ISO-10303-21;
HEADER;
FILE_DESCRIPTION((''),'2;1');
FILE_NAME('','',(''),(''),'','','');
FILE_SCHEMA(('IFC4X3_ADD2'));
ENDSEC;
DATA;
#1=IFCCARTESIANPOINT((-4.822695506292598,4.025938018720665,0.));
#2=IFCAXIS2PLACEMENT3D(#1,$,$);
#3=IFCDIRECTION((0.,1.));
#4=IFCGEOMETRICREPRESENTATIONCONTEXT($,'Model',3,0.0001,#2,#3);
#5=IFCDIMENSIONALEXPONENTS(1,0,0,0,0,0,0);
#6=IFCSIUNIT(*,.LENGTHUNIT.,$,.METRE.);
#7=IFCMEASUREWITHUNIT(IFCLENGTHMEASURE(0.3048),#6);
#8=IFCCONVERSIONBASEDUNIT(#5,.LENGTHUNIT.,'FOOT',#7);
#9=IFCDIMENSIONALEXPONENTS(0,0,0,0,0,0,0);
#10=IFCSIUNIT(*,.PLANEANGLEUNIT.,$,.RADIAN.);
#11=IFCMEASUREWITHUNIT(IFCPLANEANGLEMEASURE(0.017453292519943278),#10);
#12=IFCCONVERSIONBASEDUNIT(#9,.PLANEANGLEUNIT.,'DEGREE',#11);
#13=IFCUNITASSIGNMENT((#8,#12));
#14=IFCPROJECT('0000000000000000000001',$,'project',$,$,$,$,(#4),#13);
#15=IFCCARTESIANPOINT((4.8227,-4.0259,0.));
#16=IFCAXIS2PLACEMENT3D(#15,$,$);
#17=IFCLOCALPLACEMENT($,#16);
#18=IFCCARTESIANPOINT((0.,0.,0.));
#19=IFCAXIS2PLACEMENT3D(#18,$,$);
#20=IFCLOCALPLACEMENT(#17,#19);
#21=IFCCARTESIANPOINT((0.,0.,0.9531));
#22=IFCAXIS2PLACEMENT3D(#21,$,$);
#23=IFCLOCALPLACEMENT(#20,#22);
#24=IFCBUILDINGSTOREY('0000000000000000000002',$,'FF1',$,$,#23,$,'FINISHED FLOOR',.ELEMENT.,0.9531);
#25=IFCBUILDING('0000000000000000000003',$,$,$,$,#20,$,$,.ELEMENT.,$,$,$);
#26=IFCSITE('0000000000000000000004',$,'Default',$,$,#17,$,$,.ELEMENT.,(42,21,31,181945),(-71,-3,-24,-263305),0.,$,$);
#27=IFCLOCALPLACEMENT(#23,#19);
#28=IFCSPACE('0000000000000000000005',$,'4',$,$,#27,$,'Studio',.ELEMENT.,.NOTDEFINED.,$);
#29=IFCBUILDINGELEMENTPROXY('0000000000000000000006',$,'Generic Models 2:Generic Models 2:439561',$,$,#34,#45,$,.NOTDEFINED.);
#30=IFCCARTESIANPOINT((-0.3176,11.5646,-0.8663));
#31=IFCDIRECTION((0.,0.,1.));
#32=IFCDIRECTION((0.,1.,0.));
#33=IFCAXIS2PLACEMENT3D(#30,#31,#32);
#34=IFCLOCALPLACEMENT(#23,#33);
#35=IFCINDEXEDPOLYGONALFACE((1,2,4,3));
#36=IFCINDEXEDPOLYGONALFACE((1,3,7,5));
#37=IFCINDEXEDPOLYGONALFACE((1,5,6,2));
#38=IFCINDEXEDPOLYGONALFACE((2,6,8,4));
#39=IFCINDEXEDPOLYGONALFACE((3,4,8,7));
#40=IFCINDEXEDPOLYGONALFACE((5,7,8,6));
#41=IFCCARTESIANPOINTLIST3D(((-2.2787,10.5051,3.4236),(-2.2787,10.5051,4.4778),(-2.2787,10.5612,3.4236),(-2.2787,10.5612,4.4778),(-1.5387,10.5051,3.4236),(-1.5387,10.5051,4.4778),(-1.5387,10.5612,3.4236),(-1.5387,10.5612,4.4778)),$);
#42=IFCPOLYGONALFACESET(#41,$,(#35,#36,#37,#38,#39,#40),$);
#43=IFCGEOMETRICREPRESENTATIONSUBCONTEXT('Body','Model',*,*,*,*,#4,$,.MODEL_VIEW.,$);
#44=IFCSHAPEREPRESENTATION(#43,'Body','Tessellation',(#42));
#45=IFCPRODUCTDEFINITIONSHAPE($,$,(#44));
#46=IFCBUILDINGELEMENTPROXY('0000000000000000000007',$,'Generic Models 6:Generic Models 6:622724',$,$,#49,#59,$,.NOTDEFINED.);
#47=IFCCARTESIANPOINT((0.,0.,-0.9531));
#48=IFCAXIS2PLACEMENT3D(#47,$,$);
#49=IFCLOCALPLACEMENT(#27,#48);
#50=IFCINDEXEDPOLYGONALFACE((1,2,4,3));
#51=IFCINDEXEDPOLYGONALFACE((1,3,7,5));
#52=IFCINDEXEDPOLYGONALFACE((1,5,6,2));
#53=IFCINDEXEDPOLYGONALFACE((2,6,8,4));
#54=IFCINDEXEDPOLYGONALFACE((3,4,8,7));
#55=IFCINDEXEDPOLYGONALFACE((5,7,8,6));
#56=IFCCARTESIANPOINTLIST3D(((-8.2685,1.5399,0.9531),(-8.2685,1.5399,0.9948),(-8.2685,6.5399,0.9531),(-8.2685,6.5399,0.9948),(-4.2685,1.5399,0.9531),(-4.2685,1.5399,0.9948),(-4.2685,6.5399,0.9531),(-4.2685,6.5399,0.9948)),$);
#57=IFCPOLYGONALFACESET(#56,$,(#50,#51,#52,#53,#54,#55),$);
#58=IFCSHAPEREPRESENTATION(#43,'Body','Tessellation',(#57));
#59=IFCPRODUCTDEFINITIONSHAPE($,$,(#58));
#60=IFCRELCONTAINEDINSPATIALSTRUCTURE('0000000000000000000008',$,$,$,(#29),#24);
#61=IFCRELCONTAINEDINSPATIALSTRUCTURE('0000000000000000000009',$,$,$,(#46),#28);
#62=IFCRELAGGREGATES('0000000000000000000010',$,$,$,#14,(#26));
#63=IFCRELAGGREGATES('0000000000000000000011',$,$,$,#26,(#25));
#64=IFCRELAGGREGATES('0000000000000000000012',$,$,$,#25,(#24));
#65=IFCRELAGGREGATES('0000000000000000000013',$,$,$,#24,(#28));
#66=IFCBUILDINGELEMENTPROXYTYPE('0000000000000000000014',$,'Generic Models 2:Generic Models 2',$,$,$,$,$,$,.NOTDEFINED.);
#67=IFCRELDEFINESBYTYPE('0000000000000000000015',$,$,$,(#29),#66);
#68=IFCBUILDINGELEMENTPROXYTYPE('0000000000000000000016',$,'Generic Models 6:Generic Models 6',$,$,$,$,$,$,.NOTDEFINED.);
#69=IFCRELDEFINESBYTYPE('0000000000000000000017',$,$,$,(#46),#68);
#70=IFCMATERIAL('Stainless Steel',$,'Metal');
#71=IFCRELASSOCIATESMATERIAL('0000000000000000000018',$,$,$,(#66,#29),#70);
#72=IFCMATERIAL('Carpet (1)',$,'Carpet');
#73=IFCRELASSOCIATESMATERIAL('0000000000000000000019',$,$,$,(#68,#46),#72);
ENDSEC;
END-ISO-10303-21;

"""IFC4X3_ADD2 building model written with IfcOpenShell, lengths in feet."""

from ifc_helpers import new_model, entity, si_unit, converted_unit, direction, frame, frame_2d, origin, place, context, subcontext, project, spatial, rectangle, extrude, source, transform, mapped, material, type_object, type_shapes, element, save


model = new_model("IFC4X3_ADD2")

# Units and contexts
model_context = context("Model", 3, precision=0.0001, world=frame((-4.822695506292598, 4.025938018720665, 0.0)), true_north=direction((0.0, 1.0)))
body_context = subcontext(model_context, "Body", "Model", "MODEL_VIEW")
ifc_project = project(units=[converted_unit("LENGTHUNIT", "FOOT", entity("IfcLengthMeasure", 0.3048), si_unit("LENGTHUNIT", "METRE"), dimensions=[1, 0, 0, 0, 0, 0, 0]), converted_unit("PLANEANGLEUNIT", "DEGREE", entity("IfcPlaneAngleMeasure", 0.017453292519943278), si_unit("PLANEANGLEUNIT", "RADIAN"), dimensions=[0, 0, 0, 0, 0, 0, 0])], contexts=[model_context])

# Site, building, storey
site_placement = place(None, frame((4.8227, -4.0259, 0.0)))
site = spatial("IfcSite", under=ifc_project, at=site_placement, Name="Default", CompositionType="ELEMENT", RefLatitude=(42, 21, 31, 181945), RefLongitude=(-71, -3, -24, -263305), RefElevation=0.0)
building_placement = place(site_placement, origin())
building = spatial("IfcBuilding", under=site, at=building_placement, CompositionType="ELEMENT")
storey_placement = place(building_placement, frame((0.0, 0.0, 0.9531)))
storey = spatial("IfcBuildingStorey", under=building, at=storey_placement, Name="FF1", LongName="FINISHED FLOOR", CompositionType="ELEMENT", Elevation=0.9531)

# Shared definitions
space_placement = place(storey_placement, origin())
space = spatial("IfcSpace", under=storey, at=space_placement, Name="4", LongName="Studio", CompositionType="ELEMENT", PredefinedType="NOTDEFINED")

# Building element proxies
ifc_material_1 = material(Name="Stainless Steel", Category="Metal")
building_element_proxy_type_1 = type_object("IfcBuildingElementProxyType", Name="Generic Models 2:Generic Models 2", PredefinedType="NOTDEFINED", material=ifc_material_1)
shared_shape_1 = source(origin(), body_context, "Body", "SweptSolid", [
    extrude(rectangle(XDim=0.0561, YDim=0.74, at=frame_2d((0.0, 0.0), x_axis=(1.0, 0.0))), frame((-1.9087, 10.5331, 3.4236), z_axis=(0.0, 0.0, 1.0), x_axis=(0.0, -1.0, 0.0)), (0.0, 0.0, 1.0), 1.0542),
])
type_shapes(building_element_proxy_type_1, [shared_shape_1])
proxy_1_placement = place(storey_placement, frame((-0.3176, 11.5646, -0.8663), z_axis=(0.0, 0.0, 1.0), x_axis=(0.0, 1.0, 0.0)))
element("IfcBuildingElementProxy", 1, at=proxy_1_placement, inside=storey, type_object=building_element_proxy_type_1, material=ifc_material_1, Name="Generic Models 2:Generic Models 2:439561", PredefinedType="NOTDEFINED", context=body_context, shape_type="MappedRepresentation", body=[
    mapped(shared_shape_1, transform((0.0, 0.0, 0.0), scale=1.0)),
])
ifc_material_2 = material(Name="Carpet (1)", Category="Carpet")
building_element_proxy_type_2 = type_object("IfcBuildingElementProxyType", Name="Generic Models 6:Generic Models 6", PredefinedType="NOTDEFINED", material=ifc_material_2)
shared_shape_2 = source(origin(), body_context, "Body", "SweptSolid", [
    extrude(rectangle(XDim=4.0, YDim=5.0, at=frame_2d((0.0, 0.0), x_axis=(1.0, 0.0))), frame((-6.2685, 4.0399, 0.9531), z_axis=(0.0, 0.0, 1.0), x_axis=(-1.0, 0.0, 0.0)), (0.0, 0.0, 1.0), 0.0417),
])
type_shapes(building_element_proxy_type_2, [shared_shape_2])
proxy_2_placement = place(space_placement, frame((0.0, 0.0, -0.9531)))
element("IfcBuildingElementProxy", 2, at=proxy_2_placement, inside=space, type_object=building_element_proxy_type_2, material=ifc_material_2, Name="Generic Models 6:Generic Models 6:622724", PredefinedType="NOTDEFINED", context=body_context, shape_type="MappedRepresentation", body=[
    mapped(shared_shape_2, transform((0.0, 0.0, 0.0), scale=1.0)),
])

save(model, "model.ifc")
